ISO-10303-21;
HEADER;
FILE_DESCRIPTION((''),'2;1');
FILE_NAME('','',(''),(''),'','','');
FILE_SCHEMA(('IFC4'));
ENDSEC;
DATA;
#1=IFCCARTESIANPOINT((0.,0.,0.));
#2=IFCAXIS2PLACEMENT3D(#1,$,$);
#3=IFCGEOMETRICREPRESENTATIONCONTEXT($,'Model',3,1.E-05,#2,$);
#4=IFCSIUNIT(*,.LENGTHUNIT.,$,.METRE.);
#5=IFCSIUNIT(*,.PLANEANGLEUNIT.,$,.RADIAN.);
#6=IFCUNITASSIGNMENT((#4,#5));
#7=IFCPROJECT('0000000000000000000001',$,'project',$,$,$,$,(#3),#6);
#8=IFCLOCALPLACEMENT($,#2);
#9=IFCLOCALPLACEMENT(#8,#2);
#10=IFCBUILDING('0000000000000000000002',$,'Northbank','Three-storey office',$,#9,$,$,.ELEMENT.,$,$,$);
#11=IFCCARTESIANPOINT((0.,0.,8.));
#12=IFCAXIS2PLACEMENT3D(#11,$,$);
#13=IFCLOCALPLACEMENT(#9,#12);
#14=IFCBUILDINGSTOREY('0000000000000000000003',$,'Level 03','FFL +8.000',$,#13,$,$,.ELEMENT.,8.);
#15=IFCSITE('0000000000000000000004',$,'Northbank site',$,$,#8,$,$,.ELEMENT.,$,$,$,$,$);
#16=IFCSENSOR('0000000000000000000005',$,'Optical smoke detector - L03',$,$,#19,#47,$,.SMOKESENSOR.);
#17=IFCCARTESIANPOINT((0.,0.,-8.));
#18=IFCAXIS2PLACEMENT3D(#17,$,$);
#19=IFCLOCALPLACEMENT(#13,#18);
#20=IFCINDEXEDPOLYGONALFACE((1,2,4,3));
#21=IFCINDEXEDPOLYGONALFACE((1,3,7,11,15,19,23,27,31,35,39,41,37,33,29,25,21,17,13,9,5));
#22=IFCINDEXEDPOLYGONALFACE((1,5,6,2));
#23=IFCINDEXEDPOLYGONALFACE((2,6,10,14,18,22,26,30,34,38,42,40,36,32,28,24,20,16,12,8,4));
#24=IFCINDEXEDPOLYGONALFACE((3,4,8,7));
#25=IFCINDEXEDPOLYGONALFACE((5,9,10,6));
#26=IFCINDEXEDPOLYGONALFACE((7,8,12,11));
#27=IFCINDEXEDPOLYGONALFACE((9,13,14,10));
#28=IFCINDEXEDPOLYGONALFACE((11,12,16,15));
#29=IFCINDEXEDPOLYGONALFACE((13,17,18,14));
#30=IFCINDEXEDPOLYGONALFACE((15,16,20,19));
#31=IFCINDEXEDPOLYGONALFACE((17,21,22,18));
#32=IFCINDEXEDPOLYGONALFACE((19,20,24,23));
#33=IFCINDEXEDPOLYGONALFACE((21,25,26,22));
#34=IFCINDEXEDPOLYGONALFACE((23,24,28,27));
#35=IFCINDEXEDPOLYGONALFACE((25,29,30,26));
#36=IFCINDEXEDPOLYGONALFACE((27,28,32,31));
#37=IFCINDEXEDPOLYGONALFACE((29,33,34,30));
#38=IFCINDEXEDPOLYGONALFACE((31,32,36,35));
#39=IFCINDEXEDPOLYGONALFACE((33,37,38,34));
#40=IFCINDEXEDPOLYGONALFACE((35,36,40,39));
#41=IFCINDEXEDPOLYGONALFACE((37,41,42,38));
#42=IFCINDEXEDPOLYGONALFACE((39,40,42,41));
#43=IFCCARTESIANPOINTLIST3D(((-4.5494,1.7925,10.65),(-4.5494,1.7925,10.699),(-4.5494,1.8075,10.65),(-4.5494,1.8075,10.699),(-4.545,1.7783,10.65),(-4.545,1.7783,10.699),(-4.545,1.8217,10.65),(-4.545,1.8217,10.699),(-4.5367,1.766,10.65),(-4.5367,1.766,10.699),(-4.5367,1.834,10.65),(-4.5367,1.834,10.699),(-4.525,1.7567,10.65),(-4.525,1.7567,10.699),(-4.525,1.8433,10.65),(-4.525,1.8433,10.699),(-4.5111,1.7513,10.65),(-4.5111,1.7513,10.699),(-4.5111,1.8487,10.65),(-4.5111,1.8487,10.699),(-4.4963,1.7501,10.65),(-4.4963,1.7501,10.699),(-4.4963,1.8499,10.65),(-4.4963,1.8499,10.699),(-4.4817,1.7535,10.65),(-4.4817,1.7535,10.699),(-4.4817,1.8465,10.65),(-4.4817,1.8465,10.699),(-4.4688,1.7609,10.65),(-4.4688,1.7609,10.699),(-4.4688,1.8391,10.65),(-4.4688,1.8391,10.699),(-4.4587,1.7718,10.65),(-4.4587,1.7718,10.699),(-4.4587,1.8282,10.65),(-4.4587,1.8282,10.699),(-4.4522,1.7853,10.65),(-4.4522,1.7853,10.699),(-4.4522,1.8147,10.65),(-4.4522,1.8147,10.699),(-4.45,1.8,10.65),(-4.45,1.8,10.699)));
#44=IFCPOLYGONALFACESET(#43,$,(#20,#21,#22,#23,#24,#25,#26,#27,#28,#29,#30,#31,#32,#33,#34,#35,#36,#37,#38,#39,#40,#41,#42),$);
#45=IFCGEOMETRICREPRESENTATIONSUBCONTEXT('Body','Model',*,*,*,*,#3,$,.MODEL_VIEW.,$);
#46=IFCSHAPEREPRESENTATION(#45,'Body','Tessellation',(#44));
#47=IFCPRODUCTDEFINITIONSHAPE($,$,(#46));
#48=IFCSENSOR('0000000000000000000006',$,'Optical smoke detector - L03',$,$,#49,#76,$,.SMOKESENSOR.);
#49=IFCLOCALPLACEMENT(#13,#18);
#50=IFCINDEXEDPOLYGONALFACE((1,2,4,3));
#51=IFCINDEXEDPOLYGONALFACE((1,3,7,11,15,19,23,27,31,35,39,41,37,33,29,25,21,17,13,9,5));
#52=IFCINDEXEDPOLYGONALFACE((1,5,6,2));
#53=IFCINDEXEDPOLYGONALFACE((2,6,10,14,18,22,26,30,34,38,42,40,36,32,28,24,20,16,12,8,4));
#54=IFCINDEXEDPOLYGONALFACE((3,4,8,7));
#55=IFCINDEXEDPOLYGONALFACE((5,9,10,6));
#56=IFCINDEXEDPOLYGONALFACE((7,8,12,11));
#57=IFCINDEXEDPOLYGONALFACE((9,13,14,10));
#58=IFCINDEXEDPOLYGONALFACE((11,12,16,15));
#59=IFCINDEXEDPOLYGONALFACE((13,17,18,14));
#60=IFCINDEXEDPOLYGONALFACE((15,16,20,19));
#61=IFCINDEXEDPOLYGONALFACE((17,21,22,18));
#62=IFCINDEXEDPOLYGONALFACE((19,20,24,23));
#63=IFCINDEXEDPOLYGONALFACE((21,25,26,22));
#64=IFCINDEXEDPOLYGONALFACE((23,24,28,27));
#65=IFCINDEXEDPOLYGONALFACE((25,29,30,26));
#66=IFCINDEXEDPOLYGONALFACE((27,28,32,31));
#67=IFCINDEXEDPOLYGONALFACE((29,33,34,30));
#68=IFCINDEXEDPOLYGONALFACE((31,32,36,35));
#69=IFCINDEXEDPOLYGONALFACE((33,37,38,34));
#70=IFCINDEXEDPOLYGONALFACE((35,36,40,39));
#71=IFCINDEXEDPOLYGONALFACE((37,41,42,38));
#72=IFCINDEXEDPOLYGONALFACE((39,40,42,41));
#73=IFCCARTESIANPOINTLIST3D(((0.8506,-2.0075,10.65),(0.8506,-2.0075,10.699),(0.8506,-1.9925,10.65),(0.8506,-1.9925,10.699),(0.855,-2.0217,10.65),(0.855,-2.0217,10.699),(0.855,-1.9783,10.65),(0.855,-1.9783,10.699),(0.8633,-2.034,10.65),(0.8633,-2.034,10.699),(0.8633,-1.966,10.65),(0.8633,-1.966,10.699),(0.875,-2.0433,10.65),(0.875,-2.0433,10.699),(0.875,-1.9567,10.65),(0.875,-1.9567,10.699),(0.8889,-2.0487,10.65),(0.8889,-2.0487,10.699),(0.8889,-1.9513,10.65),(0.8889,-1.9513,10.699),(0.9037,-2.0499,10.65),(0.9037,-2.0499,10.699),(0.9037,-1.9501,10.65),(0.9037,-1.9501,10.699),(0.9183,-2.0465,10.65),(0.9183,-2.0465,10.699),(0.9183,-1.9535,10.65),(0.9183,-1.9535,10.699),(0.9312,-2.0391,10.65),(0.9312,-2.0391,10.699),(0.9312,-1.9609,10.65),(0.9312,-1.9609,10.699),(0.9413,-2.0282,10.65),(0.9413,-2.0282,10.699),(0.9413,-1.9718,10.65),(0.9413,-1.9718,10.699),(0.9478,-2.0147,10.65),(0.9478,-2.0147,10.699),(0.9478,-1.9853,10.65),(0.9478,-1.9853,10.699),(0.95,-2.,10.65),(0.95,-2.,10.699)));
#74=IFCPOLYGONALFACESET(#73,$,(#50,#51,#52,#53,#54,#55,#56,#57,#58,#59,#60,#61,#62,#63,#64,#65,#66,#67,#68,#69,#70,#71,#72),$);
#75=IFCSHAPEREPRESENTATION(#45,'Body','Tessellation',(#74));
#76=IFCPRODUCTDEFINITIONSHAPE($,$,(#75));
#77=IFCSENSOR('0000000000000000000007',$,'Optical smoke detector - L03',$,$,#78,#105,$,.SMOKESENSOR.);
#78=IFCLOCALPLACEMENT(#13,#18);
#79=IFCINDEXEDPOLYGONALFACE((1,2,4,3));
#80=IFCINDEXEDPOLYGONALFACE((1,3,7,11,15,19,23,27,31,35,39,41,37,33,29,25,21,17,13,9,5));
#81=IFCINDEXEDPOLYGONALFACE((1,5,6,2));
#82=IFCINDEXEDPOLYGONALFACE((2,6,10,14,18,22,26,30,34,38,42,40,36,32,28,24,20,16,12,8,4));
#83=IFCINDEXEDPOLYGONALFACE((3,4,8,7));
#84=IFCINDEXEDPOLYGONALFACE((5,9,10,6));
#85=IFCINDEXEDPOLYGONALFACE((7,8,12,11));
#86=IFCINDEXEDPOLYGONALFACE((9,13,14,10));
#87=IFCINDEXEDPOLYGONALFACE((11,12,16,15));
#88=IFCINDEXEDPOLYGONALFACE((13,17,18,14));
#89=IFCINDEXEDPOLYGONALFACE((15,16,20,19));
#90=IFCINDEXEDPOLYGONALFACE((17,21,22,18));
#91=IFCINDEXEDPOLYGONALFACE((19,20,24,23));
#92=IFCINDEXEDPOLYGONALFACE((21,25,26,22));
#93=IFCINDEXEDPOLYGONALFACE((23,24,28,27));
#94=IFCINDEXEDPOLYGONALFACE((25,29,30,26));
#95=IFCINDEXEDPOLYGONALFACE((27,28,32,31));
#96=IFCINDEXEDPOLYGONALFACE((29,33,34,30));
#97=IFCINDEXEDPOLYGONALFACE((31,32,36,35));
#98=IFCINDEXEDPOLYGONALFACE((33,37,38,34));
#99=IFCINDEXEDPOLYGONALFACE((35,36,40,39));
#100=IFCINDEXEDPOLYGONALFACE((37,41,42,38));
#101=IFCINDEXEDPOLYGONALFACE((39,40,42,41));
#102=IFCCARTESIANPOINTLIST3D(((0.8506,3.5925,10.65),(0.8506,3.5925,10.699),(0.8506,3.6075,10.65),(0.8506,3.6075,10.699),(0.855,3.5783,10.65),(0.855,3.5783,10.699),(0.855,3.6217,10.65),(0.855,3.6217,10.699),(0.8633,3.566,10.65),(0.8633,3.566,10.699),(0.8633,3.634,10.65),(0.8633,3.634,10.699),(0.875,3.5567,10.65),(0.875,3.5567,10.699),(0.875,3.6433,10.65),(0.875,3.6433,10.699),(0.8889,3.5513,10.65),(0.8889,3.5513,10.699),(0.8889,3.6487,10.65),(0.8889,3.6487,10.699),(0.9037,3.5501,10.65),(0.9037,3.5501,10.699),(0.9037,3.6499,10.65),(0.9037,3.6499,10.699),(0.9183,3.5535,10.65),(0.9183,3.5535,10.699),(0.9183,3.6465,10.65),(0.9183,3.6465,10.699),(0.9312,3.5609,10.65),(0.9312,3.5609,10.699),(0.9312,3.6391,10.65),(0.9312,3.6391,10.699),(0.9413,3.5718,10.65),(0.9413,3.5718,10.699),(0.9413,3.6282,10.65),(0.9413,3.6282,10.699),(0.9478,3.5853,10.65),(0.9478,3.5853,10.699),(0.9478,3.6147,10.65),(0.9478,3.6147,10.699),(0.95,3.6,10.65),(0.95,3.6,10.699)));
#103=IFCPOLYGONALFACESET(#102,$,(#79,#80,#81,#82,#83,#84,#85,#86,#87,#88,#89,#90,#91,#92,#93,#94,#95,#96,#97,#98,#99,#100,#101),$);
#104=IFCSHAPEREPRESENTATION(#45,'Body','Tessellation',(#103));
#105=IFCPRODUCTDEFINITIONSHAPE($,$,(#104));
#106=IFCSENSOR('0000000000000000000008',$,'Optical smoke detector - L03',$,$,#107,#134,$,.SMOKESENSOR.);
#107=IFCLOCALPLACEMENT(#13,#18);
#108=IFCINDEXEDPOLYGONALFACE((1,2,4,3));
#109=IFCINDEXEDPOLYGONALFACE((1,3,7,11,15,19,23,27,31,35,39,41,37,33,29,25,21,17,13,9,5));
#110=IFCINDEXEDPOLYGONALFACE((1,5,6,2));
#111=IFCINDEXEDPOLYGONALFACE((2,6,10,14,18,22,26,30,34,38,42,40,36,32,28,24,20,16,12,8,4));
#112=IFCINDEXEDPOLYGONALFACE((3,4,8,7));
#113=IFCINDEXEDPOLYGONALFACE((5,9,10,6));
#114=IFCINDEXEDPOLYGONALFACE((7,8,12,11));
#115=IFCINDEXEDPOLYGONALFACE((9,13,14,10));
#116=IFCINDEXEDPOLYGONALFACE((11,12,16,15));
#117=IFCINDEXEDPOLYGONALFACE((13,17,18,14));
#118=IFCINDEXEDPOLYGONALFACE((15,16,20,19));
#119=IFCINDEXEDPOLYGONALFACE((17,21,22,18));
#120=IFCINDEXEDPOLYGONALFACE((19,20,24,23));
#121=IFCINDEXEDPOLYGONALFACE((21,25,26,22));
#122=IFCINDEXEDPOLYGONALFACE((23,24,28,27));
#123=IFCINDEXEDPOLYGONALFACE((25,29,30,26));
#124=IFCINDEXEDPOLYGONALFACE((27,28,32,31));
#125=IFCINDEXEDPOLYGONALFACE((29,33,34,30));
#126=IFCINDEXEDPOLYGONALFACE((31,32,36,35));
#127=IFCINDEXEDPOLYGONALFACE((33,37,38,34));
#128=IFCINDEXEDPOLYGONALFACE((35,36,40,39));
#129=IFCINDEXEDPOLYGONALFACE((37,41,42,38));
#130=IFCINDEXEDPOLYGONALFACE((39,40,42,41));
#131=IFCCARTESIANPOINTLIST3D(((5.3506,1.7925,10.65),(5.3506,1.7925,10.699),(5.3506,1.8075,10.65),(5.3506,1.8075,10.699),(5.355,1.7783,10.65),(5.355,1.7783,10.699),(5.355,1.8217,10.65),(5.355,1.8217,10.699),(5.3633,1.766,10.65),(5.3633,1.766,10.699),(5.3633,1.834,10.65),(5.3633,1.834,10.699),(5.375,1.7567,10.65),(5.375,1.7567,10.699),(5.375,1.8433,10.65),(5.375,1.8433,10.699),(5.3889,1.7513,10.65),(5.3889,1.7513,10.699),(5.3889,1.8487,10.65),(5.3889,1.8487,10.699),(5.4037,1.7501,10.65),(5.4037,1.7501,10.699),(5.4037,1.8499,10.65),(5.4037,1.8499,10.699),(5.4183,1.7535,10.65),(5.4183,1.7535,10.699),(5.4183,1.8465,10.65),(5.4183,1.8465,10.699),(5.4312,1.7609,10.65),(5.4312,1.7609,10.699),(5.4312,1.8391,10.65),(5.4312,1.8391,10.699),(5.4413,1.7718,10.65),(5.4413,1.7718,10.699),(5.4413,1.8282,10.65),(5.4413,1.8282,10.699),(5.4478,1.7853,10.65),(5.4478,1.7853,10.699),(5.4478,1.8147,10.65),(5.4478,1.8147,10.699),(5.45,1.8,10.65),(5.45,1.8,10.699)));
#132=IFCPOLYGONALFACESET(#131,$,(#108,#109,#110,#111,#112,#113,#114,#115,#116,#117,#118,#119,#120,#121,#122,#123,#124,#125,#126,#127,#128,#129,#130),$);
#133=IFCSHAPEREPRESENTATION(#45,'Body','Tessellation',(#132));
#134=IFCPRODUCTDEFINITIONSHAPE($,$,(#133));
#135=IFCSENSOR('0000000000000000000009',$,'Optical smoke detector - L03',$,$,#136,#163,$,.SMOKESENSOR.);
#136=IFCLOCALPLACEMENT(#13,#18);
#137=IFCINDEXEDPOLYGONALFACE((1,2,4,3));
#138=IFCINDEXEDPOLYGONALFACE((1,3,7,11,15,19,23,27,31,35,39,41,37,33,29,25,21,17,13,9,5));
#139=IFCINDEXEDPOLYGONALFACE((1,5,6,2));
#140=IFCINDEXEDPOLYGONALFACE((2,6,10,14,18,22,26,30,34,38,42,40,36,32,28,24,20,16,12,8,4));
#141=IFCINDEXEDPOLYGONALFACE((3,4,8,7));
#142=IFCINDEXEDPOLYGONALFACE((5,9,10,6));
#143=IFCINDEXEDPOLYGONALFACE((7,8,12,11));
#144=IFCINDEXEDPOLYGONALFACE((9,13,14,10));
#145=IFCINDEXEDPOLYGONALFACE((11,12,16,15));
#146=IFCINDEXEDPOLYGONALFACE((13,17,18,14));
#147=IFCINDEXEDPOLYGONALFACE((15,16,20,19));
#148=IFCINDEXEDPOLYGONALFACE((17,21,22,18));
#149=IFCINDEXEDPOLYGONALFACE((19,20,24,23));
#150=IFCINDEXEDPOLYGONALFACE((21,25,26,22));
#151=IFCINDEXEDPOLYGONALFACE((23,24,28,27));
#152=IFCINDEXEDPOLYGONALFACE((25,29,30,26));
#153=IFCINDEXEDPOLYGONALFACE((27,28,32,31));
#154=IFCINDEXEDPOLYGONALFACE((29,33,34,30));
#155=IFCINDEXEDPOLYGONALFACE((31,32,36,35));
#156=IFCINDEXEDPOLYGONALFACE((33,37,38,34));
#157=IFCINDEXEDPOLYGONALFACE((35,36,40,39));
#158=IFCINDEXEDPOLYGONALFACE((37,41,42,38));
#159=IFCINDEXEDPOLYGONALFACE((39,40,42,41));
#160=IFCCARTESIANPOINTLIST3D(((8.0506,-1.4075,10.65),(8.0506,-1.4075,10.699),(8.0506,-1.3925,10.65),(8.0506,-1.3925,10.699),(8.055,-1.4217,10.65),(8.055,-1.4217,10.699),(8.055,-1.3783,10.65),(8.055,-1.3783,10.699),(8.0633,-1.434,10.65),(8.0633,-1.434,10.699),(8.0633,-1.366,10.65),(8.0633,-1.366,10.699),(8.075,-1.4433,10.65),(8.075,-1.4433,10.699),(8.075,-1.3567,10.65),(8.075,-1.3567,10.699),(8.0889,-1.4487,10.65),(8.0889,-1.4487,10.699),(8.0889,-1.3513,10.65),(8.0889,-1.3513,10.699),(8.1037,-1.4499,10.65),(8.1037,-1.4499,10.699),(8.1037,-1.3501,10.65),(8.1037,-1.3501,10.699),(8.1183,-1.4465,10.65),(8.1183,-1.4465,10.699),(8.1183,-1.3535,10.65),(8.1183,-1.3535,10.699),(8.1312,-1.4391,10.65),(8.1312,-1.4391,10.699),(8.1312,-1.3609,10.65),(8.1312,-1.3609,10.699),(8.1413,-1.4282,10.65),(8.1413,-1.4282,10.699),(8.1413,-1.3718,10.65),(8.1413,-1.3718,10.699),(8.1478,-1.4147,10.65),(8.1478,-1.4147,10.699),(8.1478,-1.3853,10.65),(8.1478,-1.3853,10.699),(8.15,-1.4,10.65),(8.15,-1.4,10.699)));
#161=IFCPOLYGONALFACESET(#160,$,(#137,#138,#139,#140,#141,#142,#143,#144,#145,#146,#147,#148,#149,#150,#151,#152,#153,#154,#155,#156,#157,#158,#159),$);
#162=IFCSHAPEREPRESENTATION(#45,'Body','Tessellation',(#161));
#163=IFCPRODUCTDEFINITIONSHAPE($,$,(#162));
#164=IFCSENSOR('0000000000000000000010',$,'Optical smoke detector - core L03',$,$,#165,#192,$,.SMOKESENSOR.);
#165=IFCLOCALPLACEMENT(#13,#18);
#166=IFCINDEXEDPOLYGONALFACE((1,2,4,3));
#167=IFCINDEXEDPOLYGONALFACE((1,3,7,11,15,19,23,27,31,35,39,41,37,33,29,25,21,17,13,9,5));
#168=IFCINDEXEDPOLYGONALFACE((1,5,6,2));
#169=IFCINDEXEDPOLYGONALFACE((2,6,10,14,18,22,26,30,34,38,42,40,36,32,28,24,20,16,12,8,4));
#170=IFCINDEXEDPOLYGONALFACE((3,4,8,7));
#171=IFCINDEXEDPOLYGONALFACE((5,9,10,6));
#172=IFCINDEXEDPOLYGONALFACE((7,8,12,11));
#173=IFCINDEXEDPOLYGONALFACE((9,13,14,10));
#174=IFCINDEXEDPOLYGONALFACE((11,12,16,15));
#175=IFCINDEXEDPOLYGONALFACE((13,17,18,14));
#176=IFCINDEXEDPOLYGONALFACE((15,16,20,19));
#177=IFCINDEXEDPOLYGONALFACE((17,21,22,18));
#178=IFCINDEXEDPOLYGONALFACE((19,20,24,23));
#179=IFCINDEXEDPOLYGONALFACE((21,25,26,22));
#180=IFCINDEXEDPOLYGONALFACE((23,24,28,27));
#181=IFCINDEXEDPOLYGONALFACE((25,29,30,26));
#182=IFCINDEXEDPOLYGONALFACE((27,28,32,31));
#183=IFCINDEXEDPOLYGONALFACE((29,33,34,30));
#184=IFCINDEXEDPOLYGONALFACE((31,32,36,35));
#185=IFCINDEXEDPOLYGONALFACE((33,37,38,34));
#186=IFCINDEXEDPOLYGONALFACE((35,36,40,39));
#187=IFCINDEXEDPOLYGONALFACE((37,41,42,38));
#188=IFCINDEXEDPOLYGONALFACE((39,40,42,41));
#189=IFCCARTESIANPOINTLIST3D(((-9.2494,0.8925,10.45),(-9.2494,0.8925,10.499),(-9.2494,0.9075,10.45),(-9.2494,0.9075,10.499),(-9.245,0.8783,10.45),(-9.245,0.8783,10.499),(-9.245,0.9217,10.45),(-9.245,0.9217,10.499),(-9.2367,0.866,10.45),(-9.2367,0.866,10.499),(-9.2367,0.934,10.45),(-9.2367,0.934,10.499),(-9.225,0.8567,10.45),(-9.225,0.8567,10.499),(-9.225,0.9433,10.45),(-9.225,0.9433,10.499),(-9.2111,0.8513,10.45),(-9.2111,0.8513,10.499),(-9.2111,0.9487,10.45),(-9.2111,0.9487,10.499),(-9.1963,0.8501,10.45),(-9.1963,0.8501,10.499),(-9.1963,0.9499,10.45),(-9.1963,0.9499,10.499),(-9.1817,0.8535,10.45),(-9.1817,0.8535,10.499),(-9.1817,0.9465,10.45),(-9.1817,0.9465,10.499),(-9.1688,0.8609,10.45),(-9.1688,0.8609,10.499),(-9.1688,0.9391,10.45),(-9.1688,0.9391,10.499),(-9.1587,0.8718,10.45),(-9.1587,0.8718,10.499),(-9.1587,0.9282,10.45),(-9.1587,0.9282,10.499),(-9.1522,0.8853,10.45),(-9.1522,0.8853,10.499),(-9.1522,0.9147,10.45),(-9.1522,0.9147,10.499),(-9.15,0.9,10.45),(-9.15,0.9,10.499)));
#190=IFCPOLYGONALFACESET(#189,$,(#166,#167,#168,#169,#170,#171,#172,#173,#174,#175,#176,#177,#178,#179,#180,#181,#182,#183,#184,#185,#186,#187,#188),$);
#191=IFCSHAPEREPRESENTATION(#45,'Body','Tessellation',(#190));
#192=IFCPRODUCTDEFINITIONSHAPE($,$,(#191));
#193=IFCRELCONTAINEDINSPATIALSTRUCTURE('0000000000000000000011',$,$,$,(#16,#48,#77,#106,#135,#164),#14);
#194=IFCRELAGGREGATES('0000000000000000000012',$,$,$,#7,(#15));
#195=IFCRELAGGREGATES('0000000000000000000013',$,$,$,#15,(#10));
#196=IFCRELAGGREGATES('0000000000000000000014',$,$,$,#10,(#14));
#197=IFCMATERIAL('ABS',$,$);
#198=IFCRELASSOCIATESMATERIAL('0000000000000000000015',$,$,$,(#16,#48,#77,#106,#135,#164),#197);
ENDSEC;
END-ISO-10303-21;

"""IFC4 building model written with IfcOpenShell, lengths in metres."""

from ifc_helpers import new_model, si_unit, frame, origin, place, context, subcontext, project, spatial, circle, extrude, material, element, save


model = new_model("IFC4")

# Units and contexts
model_context = context("Model", 3, precision=1e-05, world=origin())
body_context = subcontext(model_context, "Body", "Model", "MODEL_VIEW")
ifc_project = project(units=[si_unit("LENGTHUNIT", "METRE"), si_unit("PLANEANGLEUNIT", "RADIAN")], contexts=[model_context])

# Site, building, storey
site_placement = place(None, origin())
site = spatial("IfcSite", under=ifc_project, at=site_placement, Name="Northbank site", CompositionType="ELEMENT")
building_placement = place(site_placement, origin())
building = spatial("IfcBuilding", under=site, at=building_placement, Name="Northbank", Description="Three-storey office", CompositionType="ELEMENT")
storey_placement = place(building_placement, frame((0.0, 0.0, 8.0)))
storey = spatial("IfcBuildingStorey", under=building, at=storey_placement, Name="Level 03", Description="FFL +8.000", CompositionType="ELEMENT", Elevation=8.0)

# Sensors
ifc_material_1 = material(Name="ABS")
sensor_1_placement = place(storey_placement, frame((0.0, 0.0, -8.0)))
element("IfcSensor", 1, at=sensor_1_placement, inside=storey, material=ifc_material_1, Name="Optical smoke detector - L03", PredefinedType="SMOKESENSOR", context=body_context, shape_type="SweptSolid", body=[
    extrude(circle(Radius=0.05), frame((-4.5, 1.8, 10.65), z_axis=(0.0, 0.0, 1.0), x_axis=(1.0, 0.0, 0.0)), (0.0, 0.0, 1.0), 0.049),
])
sensor_2_placement = place(storey_placement, frame((0.0, 0.0, -8.0)))
element("IfcSensor", 2, at=sensor_2_placement, inside=storey, material=ifc_material_1, Name="Optical smoke detector - L03", PredefinedType="SMOKESENSOR", context=body_context, shape_type="SweptSolid", body=[
    extrude(circle(Radius=0.05), frame((0.9, -2.0, 10.65), z_axis=(0.0, 0.0, 1.0), x_axis=(1.0, 0.0, 0.0)), (0.0, 0.0, 1.0), 0.049),
])
sensor_3_placement = place(storey_placement, frame((0.0, 0.0, -8.0)))
element("IfcSensor", 3, at=sensor_3_placement, inside=storey, material=ifc_material_1, Name="Optical smoke detector - L03", PredefinedType="SMOKESENSOR", context=body_context, shape_type="SweptSolid", body=[
    extrude(circle(Radius=0.05), frame((0.9, 3.6, 10.65), z_axis=(0.0, 0.0, 1.0), x_axis=(1.0, 0.0, 0.0)), (0.0, 0.0, 1.0), 0.049),
])
sensor_4_placement = place(storey_placement, frame((0.0, 0.0, -8.0)))
element("IfcSensor", 4, at=sensor_4_placement, inside=storey, material=ifc_material_1, Name="Optical smoke detector - L03", PredefinedType="SMOKESENSOR", context=body_context, shape_type="SweptSolid", body=[
    extrude(circle(Radius=0.05), frame((5.4, 1.8, 10.65), z_axis=(0.0, 0.0, 1.0), x_axis=(1.0, 0.0, 0.0)), (0.0, 0.0, 1.0), 0.049),
])
sensor_5_placement = place(storey_placement, frame((0.0, 0.0, -8.0)))
element("IfcSensor", 5, at=sensor_5_placement, inside=storey, material=ifc_material_1, Name="Optical smoke detector - L03", PredefinedType="SMOKESENSOR", context=body_context, shape_type="SweptSolid", body=[
    extrude(circle(Radius=0.05), frame((8.1, -1.4, 10.65), z_axis=(0.0, 0.0, 1.0), x_axis=(1.0, 0.0, 0.0)), (0.0, 0.0, 1.0), 0.049),
])
sensor_6_placement = place(storey_placement, frame((0.0, 0.0, -8.0)))
element("IfcSensor", 6, at=sensor_6_placement, inside=storey, material=ifc_material_1, Name="Optical smoke detector - core L03", PredefinedType="SMOKESENSOR", context=body_context, shape_type="SweptSolid", body=[
    extrude(circle(Radius=0.05), frame((-9.2, 0.9, 10.45), z_axis=(0.0, 0.0, 1.0), x_axis=(1.0, 0.0, 0.0)), (0.0, 0.0, 1.0), 0.049),
])

save(model, "model.ifc")
